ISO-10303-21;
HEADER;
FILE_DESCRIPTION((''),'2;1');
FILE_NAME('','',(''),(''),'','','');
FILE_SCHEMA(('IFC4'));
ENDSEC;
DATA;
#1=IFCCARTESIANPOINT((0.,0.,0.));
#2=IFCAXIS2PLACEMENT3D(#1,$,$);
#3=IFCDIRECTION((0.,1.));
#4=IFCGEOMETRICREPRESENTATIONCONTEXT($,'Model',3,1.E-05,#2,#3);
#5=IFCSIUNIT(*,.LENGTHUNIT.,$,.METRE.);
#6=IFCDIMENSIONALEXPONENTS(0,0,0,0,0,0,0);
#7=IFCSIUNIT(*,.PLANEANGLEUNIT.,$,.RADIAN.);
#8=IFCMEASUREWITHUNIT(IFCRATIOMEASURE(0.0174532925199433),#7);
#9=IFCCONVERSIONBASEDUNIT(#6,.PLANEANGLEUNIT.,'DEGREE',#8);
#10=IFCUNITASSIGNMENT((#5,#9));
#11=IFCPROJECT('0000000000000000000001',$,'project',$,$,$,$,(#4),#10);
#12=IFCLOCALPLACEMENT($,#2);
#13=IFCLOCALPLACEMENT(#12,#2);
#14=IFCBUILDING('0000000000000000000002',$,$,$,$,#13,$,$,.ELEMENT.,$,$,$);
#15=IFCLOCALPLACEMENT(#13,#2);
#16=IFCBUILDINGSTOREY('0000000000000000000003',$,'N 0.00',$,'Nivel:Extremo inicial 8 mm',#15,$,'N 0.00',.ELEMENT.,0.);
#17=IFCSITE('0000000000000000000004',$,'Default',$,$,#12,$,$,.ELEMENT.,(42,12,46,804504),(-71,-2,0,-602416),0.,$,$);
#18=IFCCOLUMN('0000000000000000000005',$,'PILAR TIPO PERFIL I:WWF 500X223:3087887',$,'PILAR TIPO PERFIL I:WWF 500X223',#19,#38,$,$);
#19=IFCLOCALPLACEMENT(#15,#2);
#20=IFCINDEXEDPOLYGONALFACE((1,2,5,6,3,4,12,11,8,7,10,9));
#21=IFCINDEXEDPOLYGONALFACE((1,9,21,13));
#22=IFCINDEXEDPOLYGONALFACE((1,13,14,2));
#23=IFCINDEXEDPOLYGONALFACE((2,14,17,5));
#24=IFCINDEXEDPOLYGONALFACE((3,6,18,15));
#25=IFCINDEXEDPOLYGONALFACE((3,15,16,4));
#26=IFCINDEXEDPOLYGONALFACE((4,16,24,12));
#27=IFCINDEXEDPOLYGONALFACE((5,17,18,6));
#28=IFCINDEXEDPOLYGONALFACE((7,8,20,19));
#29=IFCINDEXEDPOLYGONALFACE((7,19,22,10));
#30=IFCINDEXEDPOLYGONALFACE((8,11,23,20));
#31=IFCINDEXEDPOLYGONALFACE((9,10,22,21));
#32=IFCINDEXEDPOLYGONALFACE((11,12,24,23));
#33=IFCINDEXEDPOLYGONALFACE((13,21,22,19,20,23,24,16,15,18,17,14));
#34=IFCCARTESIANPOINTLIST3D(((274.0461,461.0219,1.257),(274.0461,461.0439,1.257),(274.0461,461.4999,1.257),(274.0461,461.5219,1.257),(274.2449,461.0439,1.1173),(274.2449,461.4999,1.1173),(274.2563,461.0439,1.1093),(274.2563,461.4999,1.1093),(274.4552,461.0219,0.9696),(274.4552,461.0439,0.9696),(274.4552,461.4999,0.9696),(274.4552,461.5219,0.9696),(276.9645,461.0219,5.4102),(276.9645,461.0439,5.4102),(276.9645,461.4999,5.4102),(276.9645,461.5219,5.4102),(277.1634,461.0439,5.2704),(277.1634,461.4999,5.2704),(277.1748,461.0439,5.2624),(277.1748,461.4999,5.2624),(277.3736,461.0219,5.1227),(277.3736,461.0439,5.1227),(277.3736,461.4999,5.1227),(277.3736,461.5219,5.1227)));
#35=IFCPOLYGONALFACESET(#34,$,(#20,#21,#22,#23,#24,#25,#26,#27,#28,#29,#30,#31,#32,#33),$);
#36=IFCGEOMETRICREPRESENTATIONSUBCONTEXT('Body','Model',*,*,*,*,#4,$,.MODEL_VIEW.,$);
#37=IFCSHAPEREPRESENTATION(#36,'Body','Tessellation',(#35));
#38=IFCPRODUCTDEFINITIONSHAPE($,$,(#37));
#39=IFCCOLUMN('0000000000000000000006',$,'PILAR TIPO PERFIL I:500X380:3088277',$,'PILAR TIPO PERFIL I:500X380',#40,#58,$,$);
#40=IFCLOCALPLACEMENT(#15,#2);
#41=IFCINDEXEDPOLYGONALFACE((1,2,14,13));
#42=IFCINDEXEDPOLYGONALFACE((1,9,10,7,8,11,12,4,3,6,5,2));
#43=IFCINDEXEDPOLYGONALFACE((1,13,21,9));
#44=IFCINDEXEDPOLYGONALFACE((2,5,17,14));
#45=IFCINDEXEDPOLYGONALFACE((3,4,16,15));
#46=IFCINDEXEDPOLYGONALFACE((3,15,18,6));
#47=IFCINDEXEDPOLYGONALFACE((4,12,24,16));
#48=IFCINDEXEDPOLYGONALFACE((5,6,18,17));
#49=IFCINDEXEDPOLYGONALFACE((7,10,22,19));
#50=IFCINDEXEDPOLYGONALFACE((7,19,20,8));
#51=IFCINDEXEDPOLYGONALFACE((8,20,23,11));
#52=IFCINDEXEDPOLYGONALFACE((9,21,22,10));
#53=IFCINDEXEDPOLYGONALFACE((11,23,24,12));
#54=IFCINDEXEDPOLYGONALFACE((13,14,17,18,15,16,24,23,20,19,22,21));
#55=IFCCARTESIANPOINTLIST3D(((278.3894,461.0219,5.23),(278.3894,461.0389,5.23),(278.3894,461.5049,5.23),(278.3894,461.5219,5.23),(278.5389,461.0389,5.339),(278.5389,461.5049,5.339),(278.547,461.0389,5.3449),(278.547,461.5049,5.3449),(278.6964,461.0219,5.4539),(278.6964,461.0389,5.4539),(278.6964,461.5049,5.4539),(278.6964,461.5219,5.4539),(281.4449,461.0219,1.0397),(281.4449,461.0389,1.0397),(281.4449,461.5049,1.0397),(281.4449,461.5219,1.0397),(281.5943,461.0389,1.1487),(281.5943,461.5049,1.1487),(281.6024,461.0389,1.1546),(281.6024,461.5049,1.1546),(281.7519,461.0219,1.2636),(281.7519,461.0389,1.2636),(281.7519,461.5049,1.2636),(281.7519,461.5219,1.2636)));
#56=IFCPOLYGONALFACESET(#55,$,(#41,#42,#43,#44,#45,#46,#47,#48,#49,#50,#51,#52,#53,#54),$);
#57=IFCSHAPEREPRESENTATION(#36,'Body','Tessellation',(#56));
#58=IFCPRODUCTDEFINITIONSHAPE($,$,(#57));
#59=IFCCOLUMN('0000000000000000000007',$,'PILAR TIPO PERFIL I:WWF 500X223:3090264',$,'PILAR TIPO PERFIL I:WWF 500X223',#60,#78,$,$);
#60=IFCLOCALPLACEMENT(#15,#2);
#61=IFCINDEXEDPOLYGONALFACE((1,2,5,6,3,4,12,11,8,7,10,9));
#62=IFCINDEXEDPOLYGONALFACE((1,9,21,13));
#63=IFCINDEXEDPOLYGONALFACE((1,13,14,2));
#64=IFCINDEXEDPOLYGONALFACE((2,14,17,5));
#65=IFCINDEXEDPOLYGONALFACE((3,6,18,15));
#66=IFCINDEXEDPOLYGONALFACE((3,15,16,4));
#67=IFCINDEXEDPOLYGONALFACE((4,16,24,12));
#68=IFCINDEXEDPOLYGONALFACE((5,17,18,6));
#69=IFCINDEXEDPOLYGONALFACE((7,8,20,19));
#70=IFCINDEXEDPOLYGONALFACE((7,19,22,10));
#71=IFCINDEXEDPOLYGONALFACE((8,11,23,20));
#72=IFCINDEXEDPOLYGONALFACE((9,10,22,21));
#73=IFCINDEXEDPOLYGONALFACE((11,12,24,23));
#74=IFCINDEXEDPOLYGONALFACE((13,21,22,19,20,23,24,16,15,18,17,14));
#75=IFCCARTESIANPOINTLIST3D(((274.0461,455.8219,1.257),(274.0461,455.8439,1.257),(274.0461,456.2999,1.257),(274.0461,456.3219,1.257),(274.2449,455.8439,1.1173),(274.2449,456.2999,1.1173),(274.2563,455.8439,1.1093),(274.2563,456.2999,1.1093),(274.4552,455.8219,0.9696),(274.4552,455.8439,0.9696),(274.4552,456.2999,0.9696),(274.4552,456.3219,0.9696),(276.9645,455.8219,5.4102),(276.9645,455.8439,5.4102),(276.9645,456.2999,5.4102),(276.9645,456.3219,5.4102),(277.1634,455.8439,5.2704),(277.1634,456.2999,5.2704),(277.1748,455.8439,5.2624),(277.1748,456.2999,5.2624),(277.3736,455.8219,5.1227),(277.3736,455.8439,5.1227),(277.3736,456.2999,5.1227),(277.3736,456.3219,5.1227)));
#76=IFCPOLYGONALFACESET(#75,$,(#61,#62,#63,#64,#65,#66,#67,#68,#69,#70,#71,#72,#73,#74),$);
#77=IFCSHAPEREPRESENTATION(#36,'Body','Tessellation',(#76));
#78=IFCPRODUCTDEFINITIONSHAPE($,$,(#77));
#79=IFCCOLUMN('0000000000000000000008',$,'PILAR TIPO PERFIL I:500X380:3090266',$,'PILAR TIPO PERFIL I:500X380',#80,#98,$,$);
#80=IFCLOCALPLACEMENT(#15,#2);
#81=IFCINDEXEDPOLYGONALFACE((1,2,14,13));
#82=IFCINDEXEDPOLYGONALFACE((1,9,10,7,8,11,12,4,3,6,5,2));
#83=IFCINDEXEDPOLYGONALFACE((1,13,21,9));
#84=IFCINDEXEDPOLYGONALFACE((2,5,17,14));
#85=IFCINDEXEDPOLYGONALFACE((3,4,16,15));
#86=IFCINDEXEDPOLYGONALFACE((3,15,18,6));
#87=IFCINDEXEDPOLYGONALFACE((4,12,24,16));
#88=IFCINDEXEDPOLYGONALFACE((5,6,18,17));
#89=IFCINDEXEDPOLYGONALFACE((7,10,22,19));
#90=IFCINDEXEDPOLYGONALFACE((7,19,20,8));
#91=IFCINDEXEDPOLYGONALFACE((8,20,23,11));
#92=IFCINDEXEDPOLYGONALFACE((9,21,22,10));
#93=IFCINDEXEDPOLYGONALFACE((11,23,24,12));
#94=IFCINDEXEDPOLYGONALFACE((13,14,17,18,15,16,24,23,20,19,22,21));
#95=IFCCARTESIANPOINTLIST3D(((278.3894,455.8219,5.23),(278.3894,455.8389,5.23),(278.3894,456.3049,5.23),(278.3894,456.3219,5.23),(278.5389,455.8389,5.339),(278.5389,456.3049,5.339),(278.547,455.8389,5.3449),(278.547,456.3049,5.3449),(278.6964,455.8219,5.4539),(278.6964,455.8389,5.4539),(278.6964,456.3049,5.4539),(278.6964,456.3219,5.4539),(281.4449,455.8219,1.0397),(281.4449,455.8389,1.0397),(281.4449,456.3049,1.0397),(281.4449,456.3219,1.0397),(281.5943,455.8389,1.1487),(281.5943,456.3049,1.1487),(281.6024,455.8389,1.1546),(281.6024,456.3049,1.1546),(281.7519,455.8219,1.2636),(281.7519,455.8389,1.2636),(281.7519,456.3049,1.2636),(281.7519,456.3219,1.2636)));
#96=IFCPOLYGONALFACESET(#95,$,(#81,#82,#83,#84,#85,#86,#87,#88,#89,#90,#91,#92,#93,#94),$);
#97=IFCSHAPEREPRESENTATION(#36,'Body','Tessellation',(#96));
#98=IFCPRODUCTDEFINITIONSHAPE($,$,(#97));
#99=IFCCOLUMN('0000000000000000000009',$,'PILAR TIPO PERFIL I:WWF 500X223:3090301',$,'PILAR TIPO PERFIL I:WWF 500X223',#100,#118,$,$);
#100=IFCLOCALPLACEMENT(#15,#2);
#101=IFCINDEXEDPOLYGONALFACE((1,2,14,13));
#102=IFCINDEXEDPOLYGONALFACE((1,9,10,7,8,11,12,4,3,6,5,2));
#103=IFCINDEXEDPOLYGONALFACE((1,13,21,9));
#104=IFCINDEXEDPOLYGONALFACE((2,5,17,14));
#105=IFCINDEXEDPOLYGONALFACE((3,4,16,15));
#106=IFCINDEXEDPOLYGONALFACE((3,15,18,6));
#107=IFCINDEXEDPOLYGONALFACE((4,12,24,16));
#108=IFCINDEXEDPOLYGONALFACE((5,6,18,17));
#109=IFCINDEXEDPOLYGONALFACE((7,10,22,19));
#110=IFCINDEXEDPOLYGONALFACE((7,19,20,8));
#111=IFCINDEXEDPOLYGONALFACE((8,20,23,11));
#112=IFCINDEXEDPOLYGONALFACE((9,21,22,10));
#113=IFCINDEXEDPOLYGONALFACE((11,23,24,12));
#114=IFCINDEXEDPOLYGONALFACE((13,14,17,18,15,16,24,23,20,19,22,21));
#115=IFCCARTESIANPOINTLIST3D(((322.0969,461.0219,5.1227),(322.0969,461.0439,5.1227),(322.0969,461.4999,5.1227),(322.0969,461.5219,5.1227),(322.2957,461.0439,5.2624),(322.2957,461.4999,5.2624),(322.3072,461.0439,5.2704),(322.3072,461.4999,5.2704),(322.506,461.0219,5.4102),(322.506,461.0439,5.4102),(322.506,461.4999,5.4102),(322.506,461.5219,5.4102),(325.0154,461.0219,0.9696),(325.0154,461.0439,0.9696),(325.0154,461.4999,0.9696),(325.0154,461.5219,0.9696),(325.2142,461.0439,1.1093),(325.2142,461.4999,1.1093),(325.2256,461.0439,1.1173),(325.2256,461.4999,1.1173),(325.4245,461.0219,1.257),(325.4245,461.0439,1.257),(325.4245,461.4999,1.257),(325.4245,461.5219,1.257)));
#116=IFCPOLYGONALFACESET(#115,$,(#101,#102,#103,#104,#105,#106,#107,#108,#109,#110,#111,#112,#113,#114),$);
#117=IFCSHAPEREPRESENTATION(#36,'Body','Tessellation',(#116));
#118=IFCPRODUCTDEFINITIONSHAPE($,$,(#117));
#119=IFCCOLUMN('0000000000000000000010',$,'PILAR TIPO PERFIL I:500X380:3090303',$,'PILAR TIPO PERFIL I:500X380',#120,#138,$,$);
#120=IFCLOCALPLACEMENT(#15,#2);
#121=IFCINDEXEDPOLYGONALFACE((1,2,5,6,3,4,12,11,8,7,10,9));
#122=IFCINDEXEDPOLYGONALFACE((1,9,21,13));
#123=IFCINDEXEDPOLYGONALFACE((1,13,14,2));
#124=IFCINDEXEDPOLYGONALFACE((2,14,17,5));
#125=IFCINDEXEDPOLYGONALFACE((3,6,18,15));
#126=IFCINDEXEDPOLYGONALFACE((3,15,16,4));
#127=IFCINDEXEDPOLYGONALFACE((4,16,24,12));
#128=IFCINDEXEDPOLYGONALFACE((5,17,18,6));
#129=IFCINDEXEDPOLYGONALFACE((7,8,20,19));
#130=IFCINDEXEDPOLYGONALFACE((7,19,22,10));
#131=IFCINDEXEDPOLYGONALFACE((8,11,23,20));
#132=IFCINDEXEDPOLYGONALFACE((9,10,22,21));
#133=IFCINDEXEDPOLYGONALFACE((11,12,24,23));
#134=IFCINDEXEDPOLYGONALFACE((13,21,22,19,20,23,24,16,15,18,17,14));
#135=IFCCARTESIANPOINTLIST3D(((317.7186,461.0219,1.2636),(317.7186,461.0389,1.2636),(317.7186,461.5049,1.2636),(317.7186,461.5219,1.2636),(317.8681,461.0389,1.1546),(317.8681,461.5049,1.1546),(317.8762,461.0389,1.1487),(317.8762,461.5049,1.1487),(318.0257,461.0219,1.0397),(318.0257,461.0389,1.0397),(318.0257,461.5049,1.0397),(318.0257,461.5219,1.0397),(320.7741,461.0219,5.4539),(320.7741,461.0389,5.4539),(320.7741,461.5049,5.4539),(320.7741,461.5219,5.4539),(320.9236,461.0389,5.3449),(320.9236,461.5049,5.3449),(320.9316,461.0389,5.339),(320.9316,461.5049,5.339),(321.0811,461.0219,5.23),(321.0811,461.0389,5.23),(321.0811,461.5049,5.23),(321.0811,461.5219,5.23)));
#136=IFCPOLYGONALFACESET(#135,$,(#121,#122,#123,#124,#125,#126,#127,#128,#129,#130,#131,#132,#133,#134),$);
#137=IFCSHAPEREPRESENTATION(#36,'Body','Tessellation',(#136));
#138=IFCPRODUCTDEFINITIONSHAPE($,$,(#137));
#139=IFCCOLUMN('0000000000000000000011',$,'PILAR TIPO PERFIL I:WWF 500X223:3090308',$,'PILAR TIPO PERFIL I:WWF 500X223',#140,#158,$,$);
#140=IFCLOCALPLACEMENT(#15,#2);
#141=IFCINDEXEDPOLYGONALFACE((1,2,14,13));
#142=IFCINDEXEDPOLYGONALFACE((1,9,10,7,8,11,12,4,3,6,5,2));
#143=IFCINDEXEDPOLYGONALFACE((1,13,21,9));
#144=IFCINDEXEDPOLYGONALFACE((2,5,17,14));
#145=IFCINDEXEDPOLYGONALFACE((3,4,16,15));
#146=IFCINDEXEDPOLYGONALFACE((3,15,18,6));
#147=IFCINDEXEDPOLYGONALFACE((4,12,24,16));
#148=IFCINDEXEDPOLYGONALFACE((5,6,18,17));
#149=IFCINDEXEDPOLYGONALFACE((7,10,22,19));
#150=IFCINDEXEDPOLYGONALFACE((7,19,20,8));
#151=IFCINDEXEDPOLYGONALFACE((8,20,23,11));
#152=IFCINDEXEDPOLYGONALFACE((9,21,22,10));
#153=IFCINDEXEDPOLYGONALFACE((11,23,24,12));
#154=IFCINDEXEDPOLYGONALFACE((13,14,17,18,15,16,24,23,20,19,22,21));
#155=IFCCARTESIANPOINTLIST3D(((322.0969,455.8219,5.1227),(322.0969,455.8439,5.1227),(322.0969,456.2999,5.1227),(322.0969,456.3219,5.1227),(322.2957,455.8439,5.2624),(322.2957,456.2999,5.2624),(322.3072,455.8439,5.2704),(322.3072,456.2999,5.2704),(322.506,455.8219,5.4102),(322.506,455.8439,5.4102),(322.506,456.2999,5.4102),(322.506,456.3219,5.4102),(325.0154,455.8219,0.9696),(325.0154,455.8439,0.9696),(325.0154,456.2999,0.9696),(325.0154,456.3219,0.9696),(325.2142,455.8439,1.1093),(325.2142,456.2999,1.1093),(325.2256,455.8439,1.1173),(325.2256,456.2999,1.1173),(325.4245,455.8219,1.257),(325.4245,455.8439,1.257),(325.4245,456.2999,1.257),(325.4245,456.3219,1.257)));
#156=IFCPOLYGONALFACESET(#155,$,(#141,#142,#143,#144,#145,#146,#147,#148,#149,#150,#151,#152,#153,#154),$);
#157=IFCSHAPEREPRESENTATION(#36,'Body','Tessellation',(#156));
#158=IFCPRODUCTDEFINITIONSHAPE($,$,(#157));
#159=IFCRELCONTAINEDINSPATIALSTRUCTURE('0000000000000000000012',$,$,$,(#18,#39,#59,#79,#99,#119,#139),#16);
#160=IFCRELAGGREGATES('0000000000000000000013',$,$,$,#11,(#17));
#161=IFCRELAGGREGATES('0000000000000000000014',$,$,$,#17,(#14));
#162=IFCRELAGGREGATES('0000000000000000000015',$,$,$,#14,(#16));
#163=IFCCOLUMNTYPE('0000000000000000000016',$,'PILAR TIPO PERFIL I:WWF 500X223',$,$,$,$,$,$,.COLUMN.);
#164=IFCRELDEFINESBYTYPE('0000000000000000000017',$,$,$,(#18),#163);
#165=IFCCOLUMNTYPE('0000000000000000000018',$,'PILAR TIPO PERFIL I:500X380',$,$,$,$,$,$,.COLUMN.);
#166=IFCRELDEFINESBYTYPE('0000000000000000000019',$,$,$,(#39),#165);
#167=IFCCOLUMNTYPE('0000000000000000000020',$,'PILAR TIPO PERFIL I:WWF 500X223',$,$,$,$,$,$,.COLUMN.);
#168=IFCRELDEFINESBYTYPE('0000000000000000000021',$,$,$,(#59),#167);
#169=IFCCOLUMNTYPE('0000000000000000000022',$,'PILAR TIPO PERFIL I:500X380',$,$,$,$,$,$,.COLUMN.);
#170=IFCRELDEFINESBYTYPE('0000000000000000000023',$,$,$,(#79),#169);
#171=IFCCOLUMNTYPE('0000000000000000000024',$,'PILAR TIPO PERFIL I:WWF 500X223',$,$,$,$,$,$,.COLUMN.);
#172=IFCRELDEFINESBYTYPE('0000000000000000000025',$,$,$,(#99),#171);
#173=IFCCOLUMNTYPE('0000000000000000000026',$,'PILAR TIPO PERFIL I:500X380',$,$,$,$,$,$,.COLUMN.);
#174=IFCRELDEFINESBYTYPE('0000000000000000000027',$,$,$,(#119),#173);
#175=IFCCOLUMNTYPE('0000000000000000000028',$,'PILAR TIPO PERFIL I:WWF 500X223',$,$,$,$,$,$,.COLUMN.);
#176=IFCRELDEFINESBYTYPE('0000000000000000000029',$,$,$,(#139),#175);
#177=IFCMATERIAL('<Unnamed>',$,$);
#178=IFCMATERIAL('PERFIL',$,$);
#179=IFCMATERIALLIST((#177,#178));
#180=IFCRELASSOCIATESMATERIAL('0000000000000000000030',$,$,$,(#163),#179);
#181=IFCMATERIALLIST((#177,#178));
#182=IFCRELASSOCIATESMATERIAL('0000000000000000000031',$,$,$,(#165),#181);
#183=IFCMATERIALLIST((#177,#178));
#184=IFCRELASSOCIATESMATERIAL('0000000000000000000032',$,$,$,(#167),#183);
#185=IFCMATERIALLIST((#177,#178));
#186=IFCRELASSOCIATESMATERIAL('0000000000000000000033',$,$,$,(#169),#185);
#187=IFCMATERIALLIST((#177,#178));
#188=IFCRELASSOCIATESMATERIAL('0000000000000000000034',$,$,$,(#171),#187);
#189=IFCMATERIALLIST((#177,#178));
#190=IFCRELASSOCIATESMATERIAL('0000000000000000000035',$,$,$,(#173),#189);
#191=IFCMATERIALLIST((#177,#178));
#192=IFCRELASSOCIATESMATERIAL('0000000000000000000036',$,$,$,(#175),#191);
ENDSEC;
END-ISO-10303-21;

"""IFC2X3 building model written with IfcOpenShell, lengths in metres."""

from ifc_helpers import new_model, entity, si_unit, converted_unit, direction, frame, frame_2d, origin, place, context, subcontext, project, spatial, polyline, i_section, outline, extrude, source, transform, mapped, material, material_list, type_object, type_shapes, element, save


model = new_model("IFC2X3")

# Units and contexts
model_context = context("Model", 3, precision=1e-05, world=origin(), true_north=direction((0.0, 1.0)))
body_context = subcontext(model_context, "Body", "Model", "MODEL_VIEW")
ifc_project = project(units=[si_unit("LENGTHUNIT", "METRE"), converted_unit("PLANEANGLEUNIT", "DEGREE", entity("IfcRatioMeasure", 0.0174532925199433), si_unit("PLANEANGLEUNIT", "RADIAN"), dimensions=[0, 0, 0, 0, 0, 0, 0])], contexts=[model_context])

# Site, building, storey
site_placement = place(None, origin())
site = spatial("IfcSite", under=ifc_project, at=site_placement, Name="Default", CompositionType="ELEMENT", RefLatitude=(42, 12, 46, 804504), RefLongitude=(-71, -2, 0, -602416), RefElevation=0.0)
building_placement = place(site_placement, origin())
building = spatial("IfcBuilding", under=site, at=building_placement, CompositionType="ELEMENT")
storey_placement = place(building_placement, origin())
storey = spatial("IfcBuildingStorey", under=building, at=storey_placement, Name="N 0.00", ObjectType="Nivel:Extremo inicial 8 mm", LongName="N 0.00", CompositionType="ELEMENT", Elevation=0.0)

# Columns
ifc_material_1 = material(Name="<Unnamed>")
ifc_material_2 = material(Name="PERFIL")
ifc_material_list_1 = material_list([ifc_material_1, ifc_material_2])
column_type_1 = type_object("IfcColumnType", Name="PILAR TIPO PERFIL I:WWF 500X223", PredefinedType="COLUMN", material=ifc_material_list_1)
shared_shape_1 = source(origin(), body_context, "Body", "SweptSolid", [
    extrude(i_section(OverallWidth=0.5, OverallDepth=0.5, WebThickness=0.014, FlangeThickness=0.022, at=frame_2d((0.0, 0.0), x_axis=(0.0, 1.0))), frame((274.2506, 461.2719, 1.1133), z_axis=(0.574954, 0.0, 0.818186), x_axis=(0.0, -1.0, 0.0)), (0.0, 0.0, 1.0), 5.076),
])
type_shapes(column_type_1, [shared_shape_1])
column_1_placement = place(storey_placement, origin())
element("IfcColumn", 1, at=column_1_placement, inside=storey, type_object=column_type_1, Name="PILAR TIPO PERFIL I:WWF 500X223:3087887", ObjectType="PILAR TIPO PERFIL I:WWF 500X223", context=body_context, shape_type="MappedRepresentation", body=[
    mapped(shared_shape_1, transform((0.0, 0.0, 0.0), scale=1.0)),
])
ifc_material_list_2 = material_list([ifc_material_1, ifc_material_2])
column_type_2 = type_object("IfcColumnType", Name="PILAR TIPO PERFIL I:500X380", PredefinedType="COLUMN", material=ifc_material_list_2)
shared_shape_2 = source(origin(), body_context, "Body", "SweptSolid", [
    extrude(i_section(OverallWidth=0.38, OverallDepth=0.5, WebThickness=0.01, FlangeThickness=0.017, at=frame_2d((0.0, 0.0), x_axis=(0.0, 1.0))), frame((281.5984, 461.2719, 1.1516), z_axis=(-0.589174, 0.0, 0.808006), x_axis=(0.0, -1.0, 0.0)), (0.0, 0.0, 1.0), 5.186),
])
type_shapes(column_type_2, [shared_shape_2])
column_2_placement = place(storey_placement, origin())
element("IfcColumn", 2, at=column_2_placement, inside=storey, type_object=column_type_2, Name="PILAR TIPO PERFIL I:500X380:3088277", ObjectType="PILAR TIPO PERFIL I:500X380", context=body_context, shape_type="MappedRepresentation", body=[
    mapped(shared_shape_2, transform((0.0, 0.0, 0.0), scale=1.0)),
])
ifc_material_list_3 = material_list([ifc_material_1, ifc_material_2])
column_type_3 = type_object("IfcColumnType", Name="PILAR TIPO PERFIL I:WWF 500X223", PredefinedType="COLUMN", material=ifc_material_list_3)
shared_shape_3 = source(origin(), body_context, "Body", "SweptSolid", [
    extrude(outline(polyline([(0.228, -0.25), (0.25, -0.25), (0.25, 0.25), (0.228, 0.25), (0.228, 0.007), (-0.228, 0.007), (-0.228, 0.25), (-0.25, 0.25), (-0.25, -0.25), (-0.228, -0.25), (-0.228, -0.007), (0.228, -0.007), (0.228, -0.25)])), frame((274.2506, 456.0719, 1.1133), z_axis=(0.574954, 0.0, 0.818186), x_axis=(0.0, -1.0, 0.0)), (0.0, 0.0, 1.0), 5.076),
])
type_shapes(column_type_3, [shared_shape_3])
column_3_placement = place(storey_placement, origin())
element("IfcColumn", 3, at=column_3_placement, inside=storey, type_object=column_type_3, Name="PILAR TIPO PERFIL I:WWF 500X223:3090264", ObjectType="PILAR TIPO PERFIL I:WWF 500X223", context=body_context, shape_type="MappedRepresentation", body=[
    mapped(shared_shape_3, transform((0.0, 0.0, 0.0), scale=1.0)),
])
ifc_material_list_4 = material_list([ifc_material_1, ifc_material_2])
column_type_4 = type_object("IfcColumnType", Name="PILAR TIPO PERFIL I:500X380", PredefinedType="COLUMN", material=ifc_material_list_4)
shared_shape_4 = source(origin(), body_context, "Body", "SweptSolid", [
    extrude(outline(polyline([(0.233, -0.19), (0.25, -0.19), (0.25, 0.19), (0.233, 0.19), (0.233, 0.005), (-0.233, 0.005), (-0.233, 0.19), (-0.25, 0.19), (-0.25, -0.19), (-0.233, -0.19), (-0.233, -0.005), (0.233, -0.005), (0.233, -0.19)])), frame((281.5984, 456.0719, 1.1516), z_axis=(-0.589174, 0.0, 0.808006), x_axis=(0.0, -1.0, 0.0)), (0.0, 0.0, 1.0), 5.186),
])
type_shapes(column_type_4, [shared_shape_4])
column_4_placement = place(storey_placement, origin())
element("IfcColumn", 4, at=column_4_placement, inside=storey, type_object=column_type_4, Name="PILAR TIPO PERFIL I:500X380:3090266", ObjectType="PILAR TIPO PERFIL I:500X380", context=body_context, shape_type="MappedRepresentation", body=[
    mapped(shared_shape_4, transform((0.0, 0.0, 0.0), scale=1.0)),
])
ifc_material_list_5 = material_list([ifc_material_1, ifc_material_2])
column_type_5 = type_object("IfcColumnType", Name="PILAR TIPO PERFIL I:WWF 500X223", PredefinedType="COLUMN", material=ifc_material_list_5)
shared_shape_5 = source(origin(), body_context, "Body", "SweptSolid", [
    extrude(i_section(OverallWidth=0.5, OverallDepth=0.5, WebThickness=0.014, FlangeThickness=0.022, at=frame_2d((0.0, 0.0), x_axis=(0.0, 1.0))), frame((325.2199, 461.2719, 1.1133), z_axis=(-0.574954, 0.0, 0.818186), x_axis=(0.0, -1.0, 0.0)), (0.0, 0.0, 1.0), 5.076),
])
type_shapes(column_type_5, [shared_shape_5])
column_5_placement = place(storey_placement, origin())
element("IfcColumn", 5, at=column_5_placement, inside=storey, type_object=column_type_5, Name="PILAR TIPO PERFIL I:WWF 500X223:3090301", ObjectType="PILAR TIPO PERFIL I:WWF 500X223", context=body_context, shape_type="MappedRepresentation", body=[
    mapped(shared_shape_5, transform((0.0, 0.0, 0.0), scale=1.0)),
])
ifc_material_list_6 = material_list([ifc_material_1, ifc_material_2])
column_type_6 = type_object("IfcColumnType", Name="PILAR TIPO PERFIL I:500X380", PredefinedType="COLUMN", material=ifc_material_list_6)
shared_shape_6 = source(origin(), body_context, "Body", "SweptSolid", [
    extrude(i_section(OverallWidth=0.38, OverallDepth=0.5, WebThickness=0.01, FlangeThickness=0.017, at=frame_2d((0.0, 0.0), x_axis=(0.0, 1.0))), frame((317.8722, 461.2719, 1.1516), z_axis=(0.589174, 0.0, 0.808006), x_axis=(0.0, -1.0, 0.0)), (0.0, 0.0, 1.0), 5.186),
])
type_shapes(column_type_6, [shared_shape_6])
column_6_placement = place(storey_placement, origin())
element("IfcColumn", 6, at=column_6_placement, inside=storey, type_object=column_type_6, Name="PILAR TIPO PERFIL I:500X380:3090303", ObjectType="PILAR TIPO PERFIL I:500X380", context=body_context, shape_type="MappedRepresentation", body=[
    mapped(shared_shape_6, transform((0.0, 0.0, 0.0), scale=1.0)),
])
ifc_material_list_7 = material_list([ifc_material_1, ifc_material_2])
column_type_7 = type_object("IfcColumnType", Name="PILAR TIPO PERFIL I:WWF 500X223", PredefinedType="COLUMN", material=ifc_material_list_7)
shared_shape_7 = source(origin(), body_context, "Body", "SweptSolid", [
    extrude(outline(polyline([(0.228, -0.25), (0.25, -0.25), (0.25, 0.25), (0.228, 0.25), (0.228, 0.007), (-0.228, 0.007), (-0.228, 0.25), (-0.25, 0.25), (-0.25, -0.25), (-0.228, -0.25), (-0.228, -0.007), (0.228, -0.007), (0.228, -0.25)])), frame((325.2199, 456.0719, 1.1133), z_axis=(-0.574954, 0.0, 0.818186), x_axis=(0.0, -1.0, 0.0)), (0.0, 0.0, 1.0), 5.076),
])
type_shapes(column_type_7, [shared_shape_7])
column_7_placement = place(storey_placement, origin())
element("IfcColumn", 7, at=column_7_placement, inside=storey, type_object=column_type_7, Name="PILAR TIPO PERFIL I:WWF 500X223:3090308", ObjectType="PILAR TIPO PERFIL I:WWF 500X223", context=body_context, shape_type="MappedRepresentation", body=[
    mapped(shared_shape_7, transform((0.0, 0.0, 0.0), scale=1.0)),
])

save(model, "model.ifc")
